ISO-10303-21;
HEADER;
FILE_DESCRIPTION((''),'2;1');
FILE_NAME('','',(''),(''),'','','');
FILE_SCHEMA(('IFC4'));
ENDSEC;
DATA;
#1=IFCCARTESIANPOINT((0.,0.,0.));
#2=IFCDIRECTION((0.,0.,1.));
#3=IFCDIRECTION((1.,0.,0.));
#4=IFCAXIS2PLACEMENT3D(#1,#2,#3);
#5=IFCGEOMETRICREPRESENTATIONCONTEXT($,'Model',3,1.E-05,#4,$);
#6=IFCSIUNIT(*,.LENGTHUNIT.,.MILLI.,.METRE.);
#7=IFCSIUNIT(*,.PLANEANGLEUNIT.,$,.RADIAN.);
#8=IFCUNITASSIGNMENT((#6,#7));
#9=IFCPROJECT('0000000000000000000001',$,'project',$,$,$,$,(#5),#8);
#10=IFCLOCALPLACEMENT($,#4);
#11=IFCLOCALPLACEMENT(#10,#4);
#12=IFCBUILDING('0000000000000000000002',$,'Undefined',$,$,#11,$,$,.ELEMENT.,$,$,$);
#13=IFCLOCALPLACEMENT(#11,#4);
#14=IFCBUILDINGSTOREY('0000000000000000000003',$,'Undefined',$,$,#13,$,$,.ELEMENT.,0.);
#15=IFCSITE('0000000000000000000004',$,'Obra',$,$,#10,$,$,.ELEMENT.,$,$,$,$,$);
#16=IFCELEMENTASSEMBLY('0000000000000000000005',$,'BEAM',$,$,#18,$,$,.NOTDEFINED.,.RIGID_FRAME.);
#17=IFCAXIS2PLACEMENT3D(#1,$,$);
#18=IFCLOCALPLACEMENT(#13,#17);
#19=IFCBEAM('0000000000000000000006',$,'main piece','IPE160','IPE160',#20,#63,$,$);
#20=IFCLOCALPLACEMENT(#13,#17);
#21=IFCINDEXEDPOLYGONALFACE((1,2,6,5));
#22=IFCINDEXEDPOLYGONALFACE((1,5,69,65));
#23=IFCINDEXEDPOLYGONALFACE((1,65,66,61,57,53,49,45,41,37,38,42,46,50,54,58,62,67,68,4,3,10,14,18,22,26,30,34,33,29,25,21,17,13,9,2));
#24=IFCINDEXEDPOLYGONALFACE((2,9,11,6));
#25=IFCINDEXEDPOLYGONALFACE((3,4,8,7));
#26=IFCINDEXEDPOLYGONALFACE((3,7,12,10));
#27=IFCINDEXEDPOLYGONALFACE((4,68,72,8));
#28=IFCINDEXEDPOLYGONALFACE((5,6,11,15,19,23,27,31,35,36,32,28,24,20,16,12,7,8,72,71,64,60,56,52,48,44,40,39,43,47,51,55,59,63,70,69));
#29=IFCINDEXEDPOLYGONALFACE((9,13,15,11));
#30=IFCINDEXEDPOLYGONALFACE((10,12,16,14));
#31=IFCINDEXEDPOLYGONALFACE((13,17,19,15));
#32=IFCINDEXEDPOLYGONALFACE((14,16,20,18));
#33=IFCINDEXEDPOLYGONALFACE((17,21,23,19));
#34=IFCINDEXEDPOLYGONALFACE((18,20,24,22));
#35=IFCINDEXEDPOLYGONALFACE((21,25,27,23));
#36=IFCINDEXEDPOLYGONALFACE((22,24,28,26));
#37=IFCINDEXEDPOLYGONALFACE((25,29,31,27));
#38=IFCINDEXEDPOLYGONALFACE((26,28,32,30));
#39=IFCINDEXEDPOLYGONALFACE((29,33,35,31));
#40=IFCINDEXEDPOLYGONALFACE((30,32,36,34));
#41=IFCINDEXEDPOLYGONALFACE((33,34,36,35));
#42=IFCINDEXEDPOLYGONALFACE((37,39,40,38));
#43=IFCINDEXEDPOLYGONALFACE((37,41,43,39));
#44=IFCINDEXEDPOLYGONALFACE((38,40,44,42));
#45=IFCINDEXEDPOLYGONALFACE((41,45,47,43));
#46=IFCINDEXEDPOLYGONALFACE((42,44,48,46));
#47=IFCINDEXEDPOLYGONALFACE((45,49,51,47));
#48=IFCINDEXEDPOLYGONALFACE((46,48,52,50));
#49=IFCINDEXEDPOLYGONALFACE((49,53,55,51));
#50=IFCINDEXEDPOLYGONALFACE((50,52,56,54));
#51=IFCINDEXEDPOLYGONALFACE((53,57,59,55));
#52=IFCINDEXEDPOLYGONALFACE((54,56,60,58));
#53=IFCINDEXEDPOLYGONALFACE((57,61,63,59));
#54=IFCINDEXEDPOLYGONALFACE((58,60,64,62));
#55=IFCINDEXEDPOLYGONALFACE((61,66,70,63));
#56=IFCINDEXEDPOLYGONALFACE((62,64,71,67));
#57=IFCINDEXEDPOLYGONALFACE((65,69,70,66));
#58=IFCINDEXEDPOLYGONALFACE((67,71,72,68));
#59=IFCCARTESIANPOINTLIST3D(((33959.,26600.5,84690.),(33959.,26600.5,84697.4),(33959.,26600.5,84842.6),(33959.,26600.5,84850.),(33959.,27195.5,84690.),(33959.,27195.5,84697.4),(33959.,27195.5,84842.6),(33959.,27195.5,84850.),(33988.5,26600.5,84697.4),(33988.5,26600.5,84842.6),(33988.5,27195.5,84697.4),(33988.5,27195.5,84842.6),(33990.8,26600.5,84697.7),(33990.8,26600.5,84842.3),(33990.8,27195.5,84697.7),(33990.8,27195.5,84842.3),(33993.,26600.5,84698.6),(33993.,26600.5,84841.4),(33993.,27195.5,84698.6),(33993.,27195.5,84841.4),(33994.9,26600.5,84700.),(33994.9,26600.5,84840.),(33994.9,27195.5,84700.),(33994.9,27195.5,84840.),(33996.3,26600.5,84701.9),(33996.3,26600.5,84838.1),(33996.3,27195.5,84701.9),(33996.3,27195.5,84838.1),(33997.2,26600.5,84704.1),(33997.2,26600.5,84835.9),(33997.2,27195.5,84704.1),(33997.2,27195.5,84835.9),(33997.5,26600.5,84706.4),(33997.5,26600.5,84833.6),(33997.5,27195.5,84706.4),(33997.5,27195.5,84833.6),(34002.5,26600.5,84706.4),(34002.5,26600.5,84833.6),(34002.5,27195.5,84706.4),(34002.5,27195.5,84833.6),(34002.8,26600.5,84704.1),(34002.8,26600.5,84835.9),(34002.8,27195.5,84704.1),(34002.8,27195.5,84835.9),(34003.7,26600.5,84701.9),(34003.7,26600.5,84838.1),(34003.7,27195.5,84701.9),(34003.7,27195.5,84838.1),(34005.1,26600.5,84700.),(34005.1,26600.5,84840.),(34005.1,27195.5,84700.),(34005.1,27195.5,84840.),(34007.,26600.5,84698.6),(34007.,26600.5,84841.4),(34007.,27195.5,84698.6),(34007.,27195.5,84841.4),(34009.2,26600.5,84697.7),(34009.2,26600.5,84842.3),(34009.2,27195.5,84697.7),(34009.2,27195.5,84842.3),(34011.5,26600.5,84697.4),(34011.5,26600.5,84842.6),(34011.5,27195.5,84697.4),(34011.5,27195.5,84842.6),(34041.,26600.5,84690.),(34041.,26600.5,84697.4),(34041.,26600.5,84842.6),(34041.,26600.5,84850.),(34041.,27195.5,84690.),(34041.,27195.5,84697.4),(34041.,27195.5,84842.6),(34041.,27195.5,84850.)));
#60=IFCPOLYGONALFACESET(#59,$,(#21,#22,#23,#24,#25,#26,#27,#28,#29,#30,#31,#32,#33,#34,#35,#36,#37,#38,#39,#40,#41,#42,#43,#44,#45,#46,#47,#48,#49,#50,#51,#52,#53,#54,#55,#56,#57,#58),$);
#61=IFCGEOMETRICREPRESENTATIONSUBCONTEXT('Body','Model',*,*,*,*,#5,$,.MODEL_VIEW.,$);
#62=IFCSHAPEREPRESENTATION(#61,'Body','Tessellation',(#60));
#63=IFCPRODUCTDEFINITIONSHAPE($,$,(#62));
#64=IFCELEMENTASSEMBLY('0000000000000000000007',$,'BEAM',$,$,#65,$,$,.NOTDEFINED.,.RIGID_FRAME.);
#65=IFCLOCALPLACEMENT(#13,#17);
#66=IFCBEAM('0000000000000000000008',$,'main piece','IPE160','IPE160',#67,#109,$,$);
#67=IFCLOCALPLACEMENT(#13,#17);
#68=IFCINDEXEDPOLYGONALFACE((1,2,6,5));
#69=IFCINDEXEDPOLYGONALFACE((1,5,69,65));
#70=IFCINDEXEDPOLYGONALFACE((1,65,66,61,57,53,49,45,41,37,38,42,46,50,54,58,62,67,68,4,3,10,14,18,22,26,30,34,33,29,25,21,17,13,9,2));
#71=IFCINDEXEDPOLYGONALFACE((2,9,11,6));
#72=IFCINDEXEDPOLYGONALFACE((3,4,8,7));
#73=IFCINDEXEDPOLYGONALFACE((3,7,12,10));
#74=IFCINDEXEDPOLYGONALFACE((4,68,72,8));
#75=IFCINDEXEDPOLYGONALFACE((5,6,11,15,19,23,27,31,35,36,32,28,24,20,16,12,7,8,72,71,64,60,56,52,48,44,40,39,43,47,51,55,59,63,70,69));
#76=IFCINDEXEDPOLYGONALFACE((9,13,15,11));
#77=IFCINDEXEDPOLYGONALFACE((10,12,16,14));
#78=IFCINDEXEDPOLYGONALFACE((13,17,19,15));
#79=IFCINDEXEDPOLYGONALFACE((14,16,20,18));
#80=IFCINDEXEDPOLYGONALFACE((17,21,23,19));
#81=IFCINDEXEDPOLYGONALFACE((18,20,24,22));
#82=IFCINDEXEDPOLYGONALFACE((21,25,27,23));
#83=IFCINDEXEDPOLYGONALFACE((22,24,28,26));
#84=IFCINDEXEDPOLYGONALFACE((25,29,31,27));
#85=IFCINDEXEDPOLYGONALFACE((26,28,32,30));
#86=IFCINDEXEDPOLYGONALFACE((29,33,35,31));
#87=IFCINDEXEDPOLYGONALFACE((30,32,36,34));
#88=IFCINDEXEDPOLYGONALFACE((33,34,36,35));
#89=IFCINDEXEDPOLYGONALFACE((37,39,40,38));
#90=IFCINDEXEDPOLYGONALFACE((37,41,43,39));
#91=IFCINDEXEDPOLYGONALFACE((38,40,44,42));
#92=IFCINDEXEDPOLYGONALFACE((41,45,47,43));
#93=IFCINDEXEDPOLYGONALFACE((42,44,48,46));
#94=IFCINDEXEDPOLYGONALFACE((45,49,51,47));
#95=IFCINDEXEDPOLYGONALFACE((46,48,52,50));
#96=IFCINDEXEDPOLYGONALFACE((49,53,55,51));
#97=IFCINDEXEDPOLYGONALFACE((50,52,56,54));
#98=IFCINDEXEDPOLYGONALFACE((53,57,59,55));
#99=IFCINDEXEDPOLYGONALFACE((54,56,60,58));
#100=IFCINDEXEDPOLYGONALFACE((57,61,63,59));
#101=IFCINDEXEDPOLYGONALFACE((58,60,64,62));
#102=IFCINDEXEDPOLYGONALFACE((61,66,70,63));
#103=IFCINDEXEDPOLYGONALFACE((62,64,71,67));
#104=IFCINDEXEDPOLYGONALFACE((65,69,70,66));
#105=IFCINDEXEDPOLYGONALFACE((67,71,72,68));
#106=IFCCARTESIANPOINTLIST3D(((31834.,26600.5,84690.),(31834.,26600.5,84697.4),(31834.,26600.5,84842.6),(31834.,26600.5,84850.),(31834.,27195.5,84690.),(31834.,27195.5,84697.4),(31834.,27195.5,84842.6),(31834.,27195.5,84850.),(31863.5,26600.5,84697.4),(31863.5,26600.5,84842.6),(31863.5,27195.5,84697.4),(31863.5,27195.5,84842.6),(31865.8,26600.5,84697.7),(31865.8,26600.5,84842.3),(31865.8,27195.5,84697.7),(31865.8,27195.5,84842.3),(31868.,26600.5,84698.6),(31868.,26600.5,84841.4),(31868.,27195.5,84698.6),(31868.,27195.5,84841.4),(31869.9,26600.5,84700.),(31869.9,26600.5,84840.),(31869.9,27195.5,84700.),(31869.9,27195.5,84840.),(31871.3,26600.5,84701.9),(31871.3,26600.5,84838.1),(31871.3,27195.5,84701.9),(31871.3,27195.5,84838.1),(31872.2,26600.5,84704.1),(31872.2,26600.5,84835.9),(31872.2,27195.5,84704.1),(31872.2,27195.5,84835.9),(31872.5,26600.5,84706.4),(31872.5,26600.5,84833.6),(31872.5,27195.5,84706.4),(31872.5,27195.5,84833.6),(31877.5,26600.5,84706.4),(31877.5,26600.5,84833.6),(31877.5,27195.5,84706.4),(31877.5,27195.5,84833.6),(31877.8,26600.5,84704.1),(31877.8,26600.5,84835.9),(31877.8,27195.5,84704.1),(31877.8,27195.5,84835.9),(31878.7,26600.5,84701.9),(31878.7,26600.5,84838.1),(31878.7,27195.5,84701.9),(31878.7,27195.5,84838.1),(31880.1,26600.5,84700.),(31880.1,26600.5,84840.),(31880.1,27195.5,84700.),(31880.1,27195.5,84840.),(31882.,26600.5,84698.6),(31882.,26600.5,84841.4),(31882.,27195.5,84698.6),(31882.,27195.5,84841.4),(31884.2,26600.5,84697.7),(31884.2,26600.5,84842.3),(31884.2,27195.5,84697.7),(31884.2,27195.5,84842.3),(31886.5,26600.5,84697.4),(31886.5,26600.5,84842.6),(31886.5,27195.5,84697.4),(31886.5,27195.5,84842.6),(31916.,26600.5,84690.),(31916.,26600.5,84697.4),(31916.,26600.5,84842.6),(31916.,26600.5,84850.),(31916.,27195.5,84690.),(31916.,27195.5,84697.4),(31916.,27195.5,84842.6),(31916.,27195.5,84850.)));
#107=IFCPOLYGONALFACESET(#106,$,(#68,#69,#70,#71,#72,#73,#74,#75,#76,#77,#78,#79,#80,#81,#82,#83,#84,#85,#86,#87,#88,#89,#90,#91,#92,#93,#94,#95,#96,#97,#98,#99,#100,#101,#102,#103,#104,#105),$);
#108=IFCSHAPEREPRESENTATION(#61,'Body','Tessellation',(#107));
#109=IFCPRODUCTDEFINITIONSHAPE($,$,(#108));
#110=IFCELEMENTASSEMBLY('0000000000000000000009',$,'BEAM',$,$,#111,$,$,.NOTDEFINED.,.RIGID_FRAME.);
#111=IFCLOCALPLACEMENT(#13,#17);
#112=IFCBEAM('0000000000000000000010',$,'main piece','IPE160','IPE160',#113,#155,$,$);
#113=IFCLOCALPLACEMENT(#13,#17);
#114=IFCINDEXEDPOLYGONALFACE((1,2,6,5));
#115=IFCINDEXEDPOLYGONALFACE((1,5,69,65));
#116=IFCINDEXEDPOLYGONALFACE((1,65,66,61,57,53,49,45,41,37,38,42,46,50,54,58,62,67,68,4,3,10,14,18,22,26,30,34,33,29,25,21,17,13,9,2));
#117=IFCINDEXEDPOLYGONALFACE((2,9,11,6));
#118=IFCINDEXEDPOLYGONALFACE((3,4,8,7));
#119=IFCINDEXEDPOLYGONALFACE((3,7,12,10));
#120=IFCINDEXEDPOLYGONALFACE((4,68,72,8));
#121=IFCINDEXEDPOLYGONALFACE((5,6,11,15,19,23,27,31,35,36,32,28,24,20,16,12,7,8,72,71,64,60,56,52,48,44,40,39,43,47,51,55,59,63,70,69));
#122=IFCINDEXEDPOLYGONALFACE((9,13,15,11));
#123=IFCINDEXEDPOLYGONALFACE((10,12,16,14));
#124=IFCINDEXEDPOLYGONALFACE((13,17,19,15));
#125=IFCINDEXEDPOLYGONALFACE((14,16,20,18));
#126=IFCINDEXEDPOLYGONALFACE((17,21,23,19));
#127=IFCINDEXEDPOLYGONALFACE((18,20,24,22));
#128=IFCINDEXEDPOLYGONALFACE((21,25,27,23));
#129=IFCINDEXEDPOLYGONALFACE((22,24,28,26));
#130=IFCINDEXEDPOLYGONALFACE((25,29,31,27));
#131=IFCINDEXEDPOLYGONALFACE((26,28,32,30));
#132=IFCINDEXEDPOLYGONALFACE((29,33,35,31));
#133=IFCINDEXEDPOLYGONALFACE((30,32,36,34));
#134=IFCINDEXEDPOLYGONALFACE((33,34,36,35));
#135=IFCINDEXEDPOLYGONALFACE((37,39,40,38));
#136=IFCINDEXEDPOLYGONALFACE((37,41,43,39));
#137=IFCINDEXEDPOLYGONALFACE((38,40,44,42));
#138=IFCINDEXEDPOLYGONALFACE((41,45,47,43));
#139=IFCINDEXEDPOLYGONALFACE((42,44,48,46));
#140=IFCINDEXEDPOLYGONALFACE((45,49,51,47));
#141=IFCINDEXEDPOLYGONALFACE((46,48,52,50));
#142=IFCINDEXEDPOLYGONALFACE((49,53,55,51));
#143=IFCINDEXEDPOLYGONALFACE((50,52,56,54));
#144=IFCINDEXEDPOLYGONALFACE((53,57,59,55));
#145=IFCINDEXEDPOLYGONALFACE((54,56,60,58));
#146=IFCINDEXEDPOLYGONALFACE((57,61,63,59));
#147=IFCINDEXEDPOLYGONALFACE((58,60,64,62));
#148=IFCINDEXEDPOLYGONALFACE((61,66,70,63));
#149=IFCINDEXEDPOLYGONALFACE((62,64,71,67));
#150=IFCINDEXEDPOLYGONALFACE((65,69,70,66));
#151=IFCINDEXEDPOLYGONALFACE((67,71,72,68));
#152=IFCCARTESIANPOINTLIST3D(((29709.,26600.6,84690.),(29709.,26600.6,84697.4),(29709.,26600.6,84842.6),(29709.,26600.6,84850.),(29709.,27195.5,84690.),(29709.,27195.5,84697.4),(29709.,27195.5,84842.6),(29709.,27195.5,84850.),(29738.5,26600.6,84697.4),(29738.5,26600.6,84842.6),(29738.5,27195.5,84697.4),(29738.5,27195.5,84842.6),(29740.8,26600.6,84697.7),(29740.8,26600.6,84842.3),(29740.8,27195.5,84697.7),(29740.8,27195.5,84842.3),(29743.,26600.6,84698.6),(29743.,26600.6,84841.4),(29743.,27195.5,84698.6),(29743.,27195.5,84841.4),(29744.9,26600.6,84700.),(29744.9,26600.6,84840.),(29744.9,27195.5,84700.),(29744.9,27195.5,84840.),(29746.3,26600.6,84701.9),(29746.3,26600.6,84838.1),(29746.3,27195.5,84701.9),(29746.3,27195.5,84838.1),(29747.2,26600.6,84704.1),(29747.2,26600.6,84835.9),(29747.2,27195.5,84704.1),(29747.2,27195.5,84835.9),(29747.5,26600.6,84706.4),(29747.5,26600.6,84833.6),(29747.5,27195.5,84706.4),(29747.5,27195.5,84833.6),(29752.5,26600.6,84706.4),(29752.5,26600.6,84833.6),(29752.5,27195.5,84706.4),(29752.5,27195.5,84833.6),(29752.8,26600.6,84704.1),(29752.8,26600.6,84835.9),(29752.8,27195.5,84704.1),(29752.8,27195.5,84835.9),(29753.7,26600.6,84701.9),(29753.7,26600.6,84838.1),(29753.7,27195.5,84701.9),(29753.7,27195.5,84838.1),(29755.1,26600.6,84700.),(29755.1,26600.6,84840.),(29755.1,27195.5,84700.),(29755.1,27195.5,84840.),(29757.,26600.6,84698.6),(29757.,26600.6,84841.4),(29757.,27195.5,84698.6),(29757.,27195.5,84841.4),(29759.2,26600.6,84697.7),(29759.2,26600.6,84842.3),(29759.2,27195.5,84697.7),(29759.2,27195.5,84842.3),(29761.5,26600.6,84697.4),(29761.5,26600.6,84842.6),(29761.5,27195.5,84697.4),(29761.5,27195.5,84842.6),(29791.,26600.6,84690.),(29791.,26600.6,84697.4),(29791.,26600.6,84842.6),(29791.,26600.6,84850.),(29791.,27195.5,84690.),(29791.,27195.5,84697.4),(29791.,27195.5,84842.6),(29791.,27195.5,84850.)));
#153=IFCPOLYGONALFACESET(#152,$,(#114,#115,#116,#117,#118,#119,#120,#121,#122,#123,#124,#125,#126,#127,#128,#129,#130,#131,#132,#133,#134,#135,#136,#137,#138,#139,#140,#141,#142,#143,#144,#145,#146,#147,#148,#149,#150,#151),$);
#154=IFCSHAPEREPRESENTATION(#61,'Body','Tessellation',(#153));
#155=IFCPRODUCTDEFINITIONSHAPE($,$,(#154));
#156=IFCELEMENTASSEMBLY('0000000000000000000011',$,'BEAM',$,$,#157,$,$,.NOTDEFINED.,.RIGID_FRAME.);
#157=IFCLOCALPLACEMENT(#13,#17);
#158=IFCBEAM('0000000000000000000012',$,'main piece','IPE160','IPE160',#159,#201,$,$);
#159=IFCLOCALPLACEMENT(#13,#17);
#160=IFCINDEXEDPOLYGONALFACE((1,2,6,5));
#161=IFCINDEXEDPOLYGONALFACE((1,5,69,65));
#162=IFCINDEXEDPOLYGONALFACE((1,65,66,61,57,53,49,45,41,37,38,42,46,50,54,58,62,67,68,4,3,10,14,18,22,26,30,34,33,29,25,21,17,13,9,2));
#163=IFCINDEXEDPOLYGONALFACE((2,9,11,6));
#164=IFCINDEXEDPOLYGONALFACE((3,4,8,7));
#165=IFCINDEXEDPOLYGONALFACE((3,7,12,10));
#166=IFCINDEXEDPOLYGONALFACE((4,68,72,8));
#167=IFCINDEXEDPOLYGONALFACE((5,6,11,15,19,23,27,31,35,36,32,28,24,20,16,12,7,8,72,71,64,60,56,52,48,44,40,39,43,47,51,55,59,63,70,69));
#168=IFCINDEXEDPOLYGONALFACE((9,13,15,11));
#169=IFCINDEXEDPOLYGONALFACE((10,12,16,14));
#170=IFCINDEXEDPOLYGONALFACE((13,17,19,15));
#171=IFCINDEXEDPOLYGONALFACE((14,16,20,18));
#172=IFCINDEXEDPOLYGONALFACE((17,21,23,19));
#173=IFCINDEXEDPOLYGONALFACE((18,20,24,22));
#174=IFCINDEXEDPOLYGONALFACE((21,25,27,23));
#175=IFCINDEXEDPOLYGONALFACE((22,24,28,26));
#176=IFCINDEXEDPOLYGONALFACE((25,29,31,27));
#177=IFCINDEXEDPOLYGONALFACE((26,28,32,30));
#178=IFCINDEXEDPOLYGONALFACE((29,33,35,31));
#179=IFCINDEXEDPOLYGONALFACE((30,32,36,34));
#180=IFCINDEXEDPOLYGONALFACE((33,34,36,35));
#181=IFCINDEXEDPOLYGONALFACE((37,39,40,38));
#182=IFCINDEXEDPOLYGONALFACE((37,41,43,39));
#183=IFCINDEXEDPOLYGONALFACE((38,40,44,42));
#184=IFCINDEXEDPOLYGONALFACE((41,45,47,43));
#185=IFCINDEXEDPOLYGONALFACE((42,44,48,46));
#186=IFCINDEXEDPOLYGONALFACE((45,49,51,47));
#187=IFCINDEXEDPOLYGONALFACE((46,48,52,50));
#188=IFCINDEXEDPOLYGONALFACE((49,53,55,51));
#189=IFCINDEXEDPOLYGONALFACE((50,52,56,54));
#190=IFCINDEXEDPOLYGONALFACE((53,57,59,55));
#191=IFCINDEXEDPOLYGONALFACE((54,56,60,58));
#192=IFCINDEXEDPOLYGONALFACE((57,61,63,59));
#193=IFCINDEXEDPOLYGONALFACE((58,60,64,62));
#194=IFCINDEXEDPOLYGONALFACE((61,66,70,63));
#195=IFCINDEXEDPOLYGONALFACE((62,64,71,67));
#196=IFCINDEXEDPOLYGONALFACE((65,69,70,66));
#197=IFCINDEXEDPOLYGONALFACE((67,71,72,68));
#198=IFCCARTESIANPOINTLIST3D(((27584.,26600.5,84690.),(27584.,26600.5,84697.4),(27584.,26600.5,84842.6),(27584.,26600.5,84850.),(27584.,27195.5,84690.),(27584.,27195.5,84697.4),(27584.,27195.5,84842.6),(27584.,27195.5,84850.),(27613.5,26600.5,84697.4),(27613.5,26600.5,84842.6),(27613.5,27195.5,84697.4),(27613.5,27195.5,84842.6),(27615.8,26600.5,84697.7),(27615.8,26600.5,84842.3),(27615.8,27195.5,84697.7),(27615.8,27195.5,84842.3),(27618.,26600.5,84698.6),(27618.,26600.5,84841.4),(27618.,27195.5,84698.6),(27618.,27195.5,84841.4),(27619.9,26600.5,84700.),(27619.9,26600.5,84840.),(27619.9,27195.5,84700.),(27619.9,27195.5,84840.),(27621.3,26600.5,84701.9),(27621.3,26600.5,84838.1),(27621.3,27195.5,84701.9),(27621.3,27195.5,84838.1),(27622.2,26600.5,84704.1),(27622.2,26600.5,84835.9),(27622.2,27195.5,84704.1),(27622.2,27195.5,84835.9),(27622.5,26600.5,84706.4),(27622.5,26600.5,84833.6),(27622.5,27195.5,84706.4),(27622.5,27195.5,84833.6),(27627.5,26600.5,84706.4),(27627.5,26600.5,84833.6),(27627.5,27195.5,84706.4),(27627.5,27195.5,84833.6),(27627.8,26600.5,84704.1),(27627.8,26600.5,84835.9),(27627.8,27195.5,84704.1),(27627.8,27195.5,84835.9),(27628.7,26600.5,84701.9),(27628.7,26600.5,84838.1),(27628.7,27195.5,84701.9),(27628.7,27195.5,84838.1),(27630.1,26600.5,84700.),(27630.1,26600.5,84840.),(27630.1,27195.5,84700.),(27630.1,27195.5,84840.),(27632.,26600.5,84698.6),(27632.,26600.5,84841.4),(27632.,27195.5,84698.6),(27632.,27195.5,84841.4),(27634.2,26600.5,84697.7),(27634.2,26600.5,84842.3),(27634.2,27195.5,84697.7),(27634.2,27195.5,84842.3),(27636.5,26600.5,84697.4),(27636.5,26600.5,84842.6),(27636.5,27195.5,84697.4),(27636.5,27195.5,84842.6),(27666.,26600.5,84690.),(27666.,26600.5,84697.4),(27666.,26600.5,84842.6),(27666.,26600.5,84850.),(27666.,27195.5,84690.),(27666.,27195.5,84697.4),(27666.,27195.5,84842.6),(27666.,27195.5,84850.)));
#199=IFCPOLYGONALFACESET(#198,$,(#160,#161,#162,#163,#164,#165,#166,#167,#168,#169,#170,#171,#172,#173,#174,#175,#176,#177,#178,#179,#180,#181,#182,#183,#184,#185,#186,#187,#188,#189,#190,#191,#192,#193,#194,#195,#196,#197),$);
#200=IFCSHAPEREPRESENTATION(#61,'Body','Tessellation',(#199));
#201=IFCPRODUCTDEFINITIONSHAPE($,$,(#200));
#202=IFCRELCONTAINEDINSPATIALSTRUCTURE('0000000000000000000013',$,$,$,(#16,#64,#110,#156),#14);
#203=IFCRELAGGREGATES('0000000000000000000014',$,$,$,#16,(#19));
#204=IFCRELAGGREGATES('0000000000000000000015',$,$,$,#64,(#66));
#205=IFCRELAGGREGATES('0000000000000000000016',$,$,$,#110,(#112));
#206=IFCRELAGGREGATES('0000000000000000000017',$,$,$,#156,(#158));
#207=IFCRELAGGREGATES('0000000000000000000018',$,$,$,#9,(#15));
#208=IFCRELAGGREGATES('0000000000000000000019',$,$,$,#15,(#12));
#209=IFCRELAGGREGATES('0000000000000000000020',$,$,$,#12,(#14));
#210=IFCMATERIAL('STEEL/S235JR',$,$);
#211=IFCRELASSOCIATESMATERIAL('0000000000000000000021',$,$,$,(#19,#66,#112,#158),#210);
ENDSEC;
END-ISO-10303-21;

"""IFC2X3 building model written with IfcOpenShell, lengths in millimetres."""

from ifc_helpers import new_model, si_unit, frame, origin_with_axes, origin_2d_with_axis, place, context, subcontext, project, spatial, i_section, extrude, material, element, aggregate, save


model = new_model("IFC2X3")

# Units and contexts
model_context = context("Model", 3, precision=1e-05, world=origin_with_axes())
body_context = subcontext(model_context, "Body", "Model", "MODEL_VIEW")
ifc_project = project(units=[si_unit("LENGTHUNIT", "METRE", prefix="MILLI"), si_unit("PLANEANGLEUNIT", "RADIAN")], contexts=[model_context])

# Site, building, storey
site_placement = place(None, origin_with_axes())
site = spatial("IfcSite", under=ifc_project, at=site_placement, Name="Obra", CompositionType="ELEMENT")
building_placement = place(site_placement, origin_with_axes())
building = spatial("IfcBuilding", under=site, at=building_placement, Name="Undefined", CompositionType="ELEMENT")
storey_placement = place(building_placement, origin_with_axes())
storey = spatial("IfcBuildingStorey", under=building, at=storey_placement, Name="Undefined", CompositionType="ELEMENT", Elevation=0.0)

# Element assemblies, beams
assembly_1_placement = place(storey_placement, origin_with_axes())
assembly_1 = element("IfcElementAssembly", 1, at=assembly_1_placement, inside=storey, Name="BEAM", AssemblyPlace="NOTDEFINED", PredefinedType="RIGID_FRAME")
ifc_material_1 = material(Name="STEEL/S235JR")
beam_1_placement = place(assembly_1_placement, frame((34000.0, 26600.5, 84770.0), z_axis=(0.0, 0.0, 1.0), x_axis=(0.0, 1.0, 0.0)))
beam_1 = element("IfcBeam", 2, at=beam_1_placement, material=ifc_material_1, Name="main piece", Description="IPE160", ObjectType="IPE160", context=body_context, shape_type="SweptSolid", body=[
    extrude(i_section(OverallWidth=82.0, OverallDepth=160.0, WebThickness=5.0, FlangeThickness=7.4, FilletRadius=9.0, at=origin_2d_with_axis()), frame((595.1, 0.0, 0.0), z_axis=(-1.0, 0.0, 0.0), x_axis=(0.0, -1.0, 0.0)), (0.0, 0.0, 1.0), 595.0),
])
aggregate(assembly_1, [beam_1])
assembly_2_placement = place(storey_placement, origin_with_axes())
assembly_2 = element("IfcElementAssembly", 3, at=assembly_2_placement, inside=storey, Name="BEAM", AssemblyPlace="NOTDEFINED", PredefinedType="RIGID_FRAME")
beam_2_placement = place(assembly_2_placement, frame((31875.0, 26600.5, 84770.0), z_axis=(0.0, 0.0, 1.0), x_axis=(0.0, 1.0, 0.0)))
beam_2 = element("IfcBeam", 4, at=beam_2_placement, material=ifc_material_1, Name="main piece", Description="IPE160", ObjectType="IPE160", context=body_context, shape_type="SweptSolid", body=[
    extrude(i_section(OverallWidth=82.0, OverallDepth=160.0, WebThickness=5.0, FlangeThickness=7.4, FilletRadius=9.0, at=origin_2d_with_axis()), frame((595.0, 0.0, 0.0), z_axis=(-1.0, 0.0, 0.0), x_axis=(0.0, -1.0, 0.0)), (0.0, 0.0, 1.0), 595.0),
])
aggregate(assembly_2, [beam_2])
assembly_3_placement = place(storey_placement, origin_with_axes())
assembly_3 = element("IfcElementAssembly", 5, at=assembly_3_placement, inside=storey, Name="BEAM", AssemblyPlace="NOTDEFINED", PredefinedType="RIGID_FRAME")
beam_3_placement = place(assembly_3_placement, frame((29750.0, 26600.6, 84770.0), z_axis=(0.0, 0.0, 1.0), x_axis=(0.0, 1.0, 0.0)))
beam_3 = element("IfcBeam", 6, at=beam_3_placement, material=ifc_material_1, Name="main piece", Description="IPE160", ObjectType="IPE160", context=body_context, shape_type="SweptSolid", body=[
    extrude(i_section(OverallWidth=82.0, OverallDepth=160.0, WebThickness=5.0, FlangeThickness=7.4, FilletRadius=9.0, at=origin_2d_with_axis()), frame((594.9, 0.0, 0.0), z_axis=(-1.0, 0.0, 0.0), x_axis=(0.0, -1.0, 0.0)), (0.0, 0.0, 1.0), 594.9),
])
aggregate(assembly_3, [beam_3])
assembly_4_placement = place(storey_placement, origin_with_axes())
assembly_4 = element("IfcElementAssembly", 7, at=assembly_4_placement, inside=storey, Name="BEAM", AssemblyPlace="NOTDEFINED", PredefinedType="RIGID_FRAME")
beam_4_placement = place(assembly_4_placement, frame((27625.0, 26600.5, 84770.0), z_axis=(0.0, 0.0, 1.0), x_axis=(0.0, 1.0, 0.0)))
beam_4 = element("IfcBeam", 8, at=beam_4_placement, material=ifc_material_1, Name="main piece", Description="IPE160", ObjectType="IPE160", context=body_context, shape_type="SweptSolid", body=[
    extrude(i_section(OverallWidth=82.0, OverallDepth=160.0, WebThickness=5.0, FlangeThickness=7.4, FilletRadius=9.0, at=origin_2d_with_axis()), frame((595.0, 0.0, 0.0), z_axis=(-1.0, 0.0, 0.0), x_axis=(0.0, -1.0, 0.0)), (0.0, 0.0, 1.0), 595.0),
])
aggregate(assembly_4, [beam_4])

save(model, "model.ifc")
